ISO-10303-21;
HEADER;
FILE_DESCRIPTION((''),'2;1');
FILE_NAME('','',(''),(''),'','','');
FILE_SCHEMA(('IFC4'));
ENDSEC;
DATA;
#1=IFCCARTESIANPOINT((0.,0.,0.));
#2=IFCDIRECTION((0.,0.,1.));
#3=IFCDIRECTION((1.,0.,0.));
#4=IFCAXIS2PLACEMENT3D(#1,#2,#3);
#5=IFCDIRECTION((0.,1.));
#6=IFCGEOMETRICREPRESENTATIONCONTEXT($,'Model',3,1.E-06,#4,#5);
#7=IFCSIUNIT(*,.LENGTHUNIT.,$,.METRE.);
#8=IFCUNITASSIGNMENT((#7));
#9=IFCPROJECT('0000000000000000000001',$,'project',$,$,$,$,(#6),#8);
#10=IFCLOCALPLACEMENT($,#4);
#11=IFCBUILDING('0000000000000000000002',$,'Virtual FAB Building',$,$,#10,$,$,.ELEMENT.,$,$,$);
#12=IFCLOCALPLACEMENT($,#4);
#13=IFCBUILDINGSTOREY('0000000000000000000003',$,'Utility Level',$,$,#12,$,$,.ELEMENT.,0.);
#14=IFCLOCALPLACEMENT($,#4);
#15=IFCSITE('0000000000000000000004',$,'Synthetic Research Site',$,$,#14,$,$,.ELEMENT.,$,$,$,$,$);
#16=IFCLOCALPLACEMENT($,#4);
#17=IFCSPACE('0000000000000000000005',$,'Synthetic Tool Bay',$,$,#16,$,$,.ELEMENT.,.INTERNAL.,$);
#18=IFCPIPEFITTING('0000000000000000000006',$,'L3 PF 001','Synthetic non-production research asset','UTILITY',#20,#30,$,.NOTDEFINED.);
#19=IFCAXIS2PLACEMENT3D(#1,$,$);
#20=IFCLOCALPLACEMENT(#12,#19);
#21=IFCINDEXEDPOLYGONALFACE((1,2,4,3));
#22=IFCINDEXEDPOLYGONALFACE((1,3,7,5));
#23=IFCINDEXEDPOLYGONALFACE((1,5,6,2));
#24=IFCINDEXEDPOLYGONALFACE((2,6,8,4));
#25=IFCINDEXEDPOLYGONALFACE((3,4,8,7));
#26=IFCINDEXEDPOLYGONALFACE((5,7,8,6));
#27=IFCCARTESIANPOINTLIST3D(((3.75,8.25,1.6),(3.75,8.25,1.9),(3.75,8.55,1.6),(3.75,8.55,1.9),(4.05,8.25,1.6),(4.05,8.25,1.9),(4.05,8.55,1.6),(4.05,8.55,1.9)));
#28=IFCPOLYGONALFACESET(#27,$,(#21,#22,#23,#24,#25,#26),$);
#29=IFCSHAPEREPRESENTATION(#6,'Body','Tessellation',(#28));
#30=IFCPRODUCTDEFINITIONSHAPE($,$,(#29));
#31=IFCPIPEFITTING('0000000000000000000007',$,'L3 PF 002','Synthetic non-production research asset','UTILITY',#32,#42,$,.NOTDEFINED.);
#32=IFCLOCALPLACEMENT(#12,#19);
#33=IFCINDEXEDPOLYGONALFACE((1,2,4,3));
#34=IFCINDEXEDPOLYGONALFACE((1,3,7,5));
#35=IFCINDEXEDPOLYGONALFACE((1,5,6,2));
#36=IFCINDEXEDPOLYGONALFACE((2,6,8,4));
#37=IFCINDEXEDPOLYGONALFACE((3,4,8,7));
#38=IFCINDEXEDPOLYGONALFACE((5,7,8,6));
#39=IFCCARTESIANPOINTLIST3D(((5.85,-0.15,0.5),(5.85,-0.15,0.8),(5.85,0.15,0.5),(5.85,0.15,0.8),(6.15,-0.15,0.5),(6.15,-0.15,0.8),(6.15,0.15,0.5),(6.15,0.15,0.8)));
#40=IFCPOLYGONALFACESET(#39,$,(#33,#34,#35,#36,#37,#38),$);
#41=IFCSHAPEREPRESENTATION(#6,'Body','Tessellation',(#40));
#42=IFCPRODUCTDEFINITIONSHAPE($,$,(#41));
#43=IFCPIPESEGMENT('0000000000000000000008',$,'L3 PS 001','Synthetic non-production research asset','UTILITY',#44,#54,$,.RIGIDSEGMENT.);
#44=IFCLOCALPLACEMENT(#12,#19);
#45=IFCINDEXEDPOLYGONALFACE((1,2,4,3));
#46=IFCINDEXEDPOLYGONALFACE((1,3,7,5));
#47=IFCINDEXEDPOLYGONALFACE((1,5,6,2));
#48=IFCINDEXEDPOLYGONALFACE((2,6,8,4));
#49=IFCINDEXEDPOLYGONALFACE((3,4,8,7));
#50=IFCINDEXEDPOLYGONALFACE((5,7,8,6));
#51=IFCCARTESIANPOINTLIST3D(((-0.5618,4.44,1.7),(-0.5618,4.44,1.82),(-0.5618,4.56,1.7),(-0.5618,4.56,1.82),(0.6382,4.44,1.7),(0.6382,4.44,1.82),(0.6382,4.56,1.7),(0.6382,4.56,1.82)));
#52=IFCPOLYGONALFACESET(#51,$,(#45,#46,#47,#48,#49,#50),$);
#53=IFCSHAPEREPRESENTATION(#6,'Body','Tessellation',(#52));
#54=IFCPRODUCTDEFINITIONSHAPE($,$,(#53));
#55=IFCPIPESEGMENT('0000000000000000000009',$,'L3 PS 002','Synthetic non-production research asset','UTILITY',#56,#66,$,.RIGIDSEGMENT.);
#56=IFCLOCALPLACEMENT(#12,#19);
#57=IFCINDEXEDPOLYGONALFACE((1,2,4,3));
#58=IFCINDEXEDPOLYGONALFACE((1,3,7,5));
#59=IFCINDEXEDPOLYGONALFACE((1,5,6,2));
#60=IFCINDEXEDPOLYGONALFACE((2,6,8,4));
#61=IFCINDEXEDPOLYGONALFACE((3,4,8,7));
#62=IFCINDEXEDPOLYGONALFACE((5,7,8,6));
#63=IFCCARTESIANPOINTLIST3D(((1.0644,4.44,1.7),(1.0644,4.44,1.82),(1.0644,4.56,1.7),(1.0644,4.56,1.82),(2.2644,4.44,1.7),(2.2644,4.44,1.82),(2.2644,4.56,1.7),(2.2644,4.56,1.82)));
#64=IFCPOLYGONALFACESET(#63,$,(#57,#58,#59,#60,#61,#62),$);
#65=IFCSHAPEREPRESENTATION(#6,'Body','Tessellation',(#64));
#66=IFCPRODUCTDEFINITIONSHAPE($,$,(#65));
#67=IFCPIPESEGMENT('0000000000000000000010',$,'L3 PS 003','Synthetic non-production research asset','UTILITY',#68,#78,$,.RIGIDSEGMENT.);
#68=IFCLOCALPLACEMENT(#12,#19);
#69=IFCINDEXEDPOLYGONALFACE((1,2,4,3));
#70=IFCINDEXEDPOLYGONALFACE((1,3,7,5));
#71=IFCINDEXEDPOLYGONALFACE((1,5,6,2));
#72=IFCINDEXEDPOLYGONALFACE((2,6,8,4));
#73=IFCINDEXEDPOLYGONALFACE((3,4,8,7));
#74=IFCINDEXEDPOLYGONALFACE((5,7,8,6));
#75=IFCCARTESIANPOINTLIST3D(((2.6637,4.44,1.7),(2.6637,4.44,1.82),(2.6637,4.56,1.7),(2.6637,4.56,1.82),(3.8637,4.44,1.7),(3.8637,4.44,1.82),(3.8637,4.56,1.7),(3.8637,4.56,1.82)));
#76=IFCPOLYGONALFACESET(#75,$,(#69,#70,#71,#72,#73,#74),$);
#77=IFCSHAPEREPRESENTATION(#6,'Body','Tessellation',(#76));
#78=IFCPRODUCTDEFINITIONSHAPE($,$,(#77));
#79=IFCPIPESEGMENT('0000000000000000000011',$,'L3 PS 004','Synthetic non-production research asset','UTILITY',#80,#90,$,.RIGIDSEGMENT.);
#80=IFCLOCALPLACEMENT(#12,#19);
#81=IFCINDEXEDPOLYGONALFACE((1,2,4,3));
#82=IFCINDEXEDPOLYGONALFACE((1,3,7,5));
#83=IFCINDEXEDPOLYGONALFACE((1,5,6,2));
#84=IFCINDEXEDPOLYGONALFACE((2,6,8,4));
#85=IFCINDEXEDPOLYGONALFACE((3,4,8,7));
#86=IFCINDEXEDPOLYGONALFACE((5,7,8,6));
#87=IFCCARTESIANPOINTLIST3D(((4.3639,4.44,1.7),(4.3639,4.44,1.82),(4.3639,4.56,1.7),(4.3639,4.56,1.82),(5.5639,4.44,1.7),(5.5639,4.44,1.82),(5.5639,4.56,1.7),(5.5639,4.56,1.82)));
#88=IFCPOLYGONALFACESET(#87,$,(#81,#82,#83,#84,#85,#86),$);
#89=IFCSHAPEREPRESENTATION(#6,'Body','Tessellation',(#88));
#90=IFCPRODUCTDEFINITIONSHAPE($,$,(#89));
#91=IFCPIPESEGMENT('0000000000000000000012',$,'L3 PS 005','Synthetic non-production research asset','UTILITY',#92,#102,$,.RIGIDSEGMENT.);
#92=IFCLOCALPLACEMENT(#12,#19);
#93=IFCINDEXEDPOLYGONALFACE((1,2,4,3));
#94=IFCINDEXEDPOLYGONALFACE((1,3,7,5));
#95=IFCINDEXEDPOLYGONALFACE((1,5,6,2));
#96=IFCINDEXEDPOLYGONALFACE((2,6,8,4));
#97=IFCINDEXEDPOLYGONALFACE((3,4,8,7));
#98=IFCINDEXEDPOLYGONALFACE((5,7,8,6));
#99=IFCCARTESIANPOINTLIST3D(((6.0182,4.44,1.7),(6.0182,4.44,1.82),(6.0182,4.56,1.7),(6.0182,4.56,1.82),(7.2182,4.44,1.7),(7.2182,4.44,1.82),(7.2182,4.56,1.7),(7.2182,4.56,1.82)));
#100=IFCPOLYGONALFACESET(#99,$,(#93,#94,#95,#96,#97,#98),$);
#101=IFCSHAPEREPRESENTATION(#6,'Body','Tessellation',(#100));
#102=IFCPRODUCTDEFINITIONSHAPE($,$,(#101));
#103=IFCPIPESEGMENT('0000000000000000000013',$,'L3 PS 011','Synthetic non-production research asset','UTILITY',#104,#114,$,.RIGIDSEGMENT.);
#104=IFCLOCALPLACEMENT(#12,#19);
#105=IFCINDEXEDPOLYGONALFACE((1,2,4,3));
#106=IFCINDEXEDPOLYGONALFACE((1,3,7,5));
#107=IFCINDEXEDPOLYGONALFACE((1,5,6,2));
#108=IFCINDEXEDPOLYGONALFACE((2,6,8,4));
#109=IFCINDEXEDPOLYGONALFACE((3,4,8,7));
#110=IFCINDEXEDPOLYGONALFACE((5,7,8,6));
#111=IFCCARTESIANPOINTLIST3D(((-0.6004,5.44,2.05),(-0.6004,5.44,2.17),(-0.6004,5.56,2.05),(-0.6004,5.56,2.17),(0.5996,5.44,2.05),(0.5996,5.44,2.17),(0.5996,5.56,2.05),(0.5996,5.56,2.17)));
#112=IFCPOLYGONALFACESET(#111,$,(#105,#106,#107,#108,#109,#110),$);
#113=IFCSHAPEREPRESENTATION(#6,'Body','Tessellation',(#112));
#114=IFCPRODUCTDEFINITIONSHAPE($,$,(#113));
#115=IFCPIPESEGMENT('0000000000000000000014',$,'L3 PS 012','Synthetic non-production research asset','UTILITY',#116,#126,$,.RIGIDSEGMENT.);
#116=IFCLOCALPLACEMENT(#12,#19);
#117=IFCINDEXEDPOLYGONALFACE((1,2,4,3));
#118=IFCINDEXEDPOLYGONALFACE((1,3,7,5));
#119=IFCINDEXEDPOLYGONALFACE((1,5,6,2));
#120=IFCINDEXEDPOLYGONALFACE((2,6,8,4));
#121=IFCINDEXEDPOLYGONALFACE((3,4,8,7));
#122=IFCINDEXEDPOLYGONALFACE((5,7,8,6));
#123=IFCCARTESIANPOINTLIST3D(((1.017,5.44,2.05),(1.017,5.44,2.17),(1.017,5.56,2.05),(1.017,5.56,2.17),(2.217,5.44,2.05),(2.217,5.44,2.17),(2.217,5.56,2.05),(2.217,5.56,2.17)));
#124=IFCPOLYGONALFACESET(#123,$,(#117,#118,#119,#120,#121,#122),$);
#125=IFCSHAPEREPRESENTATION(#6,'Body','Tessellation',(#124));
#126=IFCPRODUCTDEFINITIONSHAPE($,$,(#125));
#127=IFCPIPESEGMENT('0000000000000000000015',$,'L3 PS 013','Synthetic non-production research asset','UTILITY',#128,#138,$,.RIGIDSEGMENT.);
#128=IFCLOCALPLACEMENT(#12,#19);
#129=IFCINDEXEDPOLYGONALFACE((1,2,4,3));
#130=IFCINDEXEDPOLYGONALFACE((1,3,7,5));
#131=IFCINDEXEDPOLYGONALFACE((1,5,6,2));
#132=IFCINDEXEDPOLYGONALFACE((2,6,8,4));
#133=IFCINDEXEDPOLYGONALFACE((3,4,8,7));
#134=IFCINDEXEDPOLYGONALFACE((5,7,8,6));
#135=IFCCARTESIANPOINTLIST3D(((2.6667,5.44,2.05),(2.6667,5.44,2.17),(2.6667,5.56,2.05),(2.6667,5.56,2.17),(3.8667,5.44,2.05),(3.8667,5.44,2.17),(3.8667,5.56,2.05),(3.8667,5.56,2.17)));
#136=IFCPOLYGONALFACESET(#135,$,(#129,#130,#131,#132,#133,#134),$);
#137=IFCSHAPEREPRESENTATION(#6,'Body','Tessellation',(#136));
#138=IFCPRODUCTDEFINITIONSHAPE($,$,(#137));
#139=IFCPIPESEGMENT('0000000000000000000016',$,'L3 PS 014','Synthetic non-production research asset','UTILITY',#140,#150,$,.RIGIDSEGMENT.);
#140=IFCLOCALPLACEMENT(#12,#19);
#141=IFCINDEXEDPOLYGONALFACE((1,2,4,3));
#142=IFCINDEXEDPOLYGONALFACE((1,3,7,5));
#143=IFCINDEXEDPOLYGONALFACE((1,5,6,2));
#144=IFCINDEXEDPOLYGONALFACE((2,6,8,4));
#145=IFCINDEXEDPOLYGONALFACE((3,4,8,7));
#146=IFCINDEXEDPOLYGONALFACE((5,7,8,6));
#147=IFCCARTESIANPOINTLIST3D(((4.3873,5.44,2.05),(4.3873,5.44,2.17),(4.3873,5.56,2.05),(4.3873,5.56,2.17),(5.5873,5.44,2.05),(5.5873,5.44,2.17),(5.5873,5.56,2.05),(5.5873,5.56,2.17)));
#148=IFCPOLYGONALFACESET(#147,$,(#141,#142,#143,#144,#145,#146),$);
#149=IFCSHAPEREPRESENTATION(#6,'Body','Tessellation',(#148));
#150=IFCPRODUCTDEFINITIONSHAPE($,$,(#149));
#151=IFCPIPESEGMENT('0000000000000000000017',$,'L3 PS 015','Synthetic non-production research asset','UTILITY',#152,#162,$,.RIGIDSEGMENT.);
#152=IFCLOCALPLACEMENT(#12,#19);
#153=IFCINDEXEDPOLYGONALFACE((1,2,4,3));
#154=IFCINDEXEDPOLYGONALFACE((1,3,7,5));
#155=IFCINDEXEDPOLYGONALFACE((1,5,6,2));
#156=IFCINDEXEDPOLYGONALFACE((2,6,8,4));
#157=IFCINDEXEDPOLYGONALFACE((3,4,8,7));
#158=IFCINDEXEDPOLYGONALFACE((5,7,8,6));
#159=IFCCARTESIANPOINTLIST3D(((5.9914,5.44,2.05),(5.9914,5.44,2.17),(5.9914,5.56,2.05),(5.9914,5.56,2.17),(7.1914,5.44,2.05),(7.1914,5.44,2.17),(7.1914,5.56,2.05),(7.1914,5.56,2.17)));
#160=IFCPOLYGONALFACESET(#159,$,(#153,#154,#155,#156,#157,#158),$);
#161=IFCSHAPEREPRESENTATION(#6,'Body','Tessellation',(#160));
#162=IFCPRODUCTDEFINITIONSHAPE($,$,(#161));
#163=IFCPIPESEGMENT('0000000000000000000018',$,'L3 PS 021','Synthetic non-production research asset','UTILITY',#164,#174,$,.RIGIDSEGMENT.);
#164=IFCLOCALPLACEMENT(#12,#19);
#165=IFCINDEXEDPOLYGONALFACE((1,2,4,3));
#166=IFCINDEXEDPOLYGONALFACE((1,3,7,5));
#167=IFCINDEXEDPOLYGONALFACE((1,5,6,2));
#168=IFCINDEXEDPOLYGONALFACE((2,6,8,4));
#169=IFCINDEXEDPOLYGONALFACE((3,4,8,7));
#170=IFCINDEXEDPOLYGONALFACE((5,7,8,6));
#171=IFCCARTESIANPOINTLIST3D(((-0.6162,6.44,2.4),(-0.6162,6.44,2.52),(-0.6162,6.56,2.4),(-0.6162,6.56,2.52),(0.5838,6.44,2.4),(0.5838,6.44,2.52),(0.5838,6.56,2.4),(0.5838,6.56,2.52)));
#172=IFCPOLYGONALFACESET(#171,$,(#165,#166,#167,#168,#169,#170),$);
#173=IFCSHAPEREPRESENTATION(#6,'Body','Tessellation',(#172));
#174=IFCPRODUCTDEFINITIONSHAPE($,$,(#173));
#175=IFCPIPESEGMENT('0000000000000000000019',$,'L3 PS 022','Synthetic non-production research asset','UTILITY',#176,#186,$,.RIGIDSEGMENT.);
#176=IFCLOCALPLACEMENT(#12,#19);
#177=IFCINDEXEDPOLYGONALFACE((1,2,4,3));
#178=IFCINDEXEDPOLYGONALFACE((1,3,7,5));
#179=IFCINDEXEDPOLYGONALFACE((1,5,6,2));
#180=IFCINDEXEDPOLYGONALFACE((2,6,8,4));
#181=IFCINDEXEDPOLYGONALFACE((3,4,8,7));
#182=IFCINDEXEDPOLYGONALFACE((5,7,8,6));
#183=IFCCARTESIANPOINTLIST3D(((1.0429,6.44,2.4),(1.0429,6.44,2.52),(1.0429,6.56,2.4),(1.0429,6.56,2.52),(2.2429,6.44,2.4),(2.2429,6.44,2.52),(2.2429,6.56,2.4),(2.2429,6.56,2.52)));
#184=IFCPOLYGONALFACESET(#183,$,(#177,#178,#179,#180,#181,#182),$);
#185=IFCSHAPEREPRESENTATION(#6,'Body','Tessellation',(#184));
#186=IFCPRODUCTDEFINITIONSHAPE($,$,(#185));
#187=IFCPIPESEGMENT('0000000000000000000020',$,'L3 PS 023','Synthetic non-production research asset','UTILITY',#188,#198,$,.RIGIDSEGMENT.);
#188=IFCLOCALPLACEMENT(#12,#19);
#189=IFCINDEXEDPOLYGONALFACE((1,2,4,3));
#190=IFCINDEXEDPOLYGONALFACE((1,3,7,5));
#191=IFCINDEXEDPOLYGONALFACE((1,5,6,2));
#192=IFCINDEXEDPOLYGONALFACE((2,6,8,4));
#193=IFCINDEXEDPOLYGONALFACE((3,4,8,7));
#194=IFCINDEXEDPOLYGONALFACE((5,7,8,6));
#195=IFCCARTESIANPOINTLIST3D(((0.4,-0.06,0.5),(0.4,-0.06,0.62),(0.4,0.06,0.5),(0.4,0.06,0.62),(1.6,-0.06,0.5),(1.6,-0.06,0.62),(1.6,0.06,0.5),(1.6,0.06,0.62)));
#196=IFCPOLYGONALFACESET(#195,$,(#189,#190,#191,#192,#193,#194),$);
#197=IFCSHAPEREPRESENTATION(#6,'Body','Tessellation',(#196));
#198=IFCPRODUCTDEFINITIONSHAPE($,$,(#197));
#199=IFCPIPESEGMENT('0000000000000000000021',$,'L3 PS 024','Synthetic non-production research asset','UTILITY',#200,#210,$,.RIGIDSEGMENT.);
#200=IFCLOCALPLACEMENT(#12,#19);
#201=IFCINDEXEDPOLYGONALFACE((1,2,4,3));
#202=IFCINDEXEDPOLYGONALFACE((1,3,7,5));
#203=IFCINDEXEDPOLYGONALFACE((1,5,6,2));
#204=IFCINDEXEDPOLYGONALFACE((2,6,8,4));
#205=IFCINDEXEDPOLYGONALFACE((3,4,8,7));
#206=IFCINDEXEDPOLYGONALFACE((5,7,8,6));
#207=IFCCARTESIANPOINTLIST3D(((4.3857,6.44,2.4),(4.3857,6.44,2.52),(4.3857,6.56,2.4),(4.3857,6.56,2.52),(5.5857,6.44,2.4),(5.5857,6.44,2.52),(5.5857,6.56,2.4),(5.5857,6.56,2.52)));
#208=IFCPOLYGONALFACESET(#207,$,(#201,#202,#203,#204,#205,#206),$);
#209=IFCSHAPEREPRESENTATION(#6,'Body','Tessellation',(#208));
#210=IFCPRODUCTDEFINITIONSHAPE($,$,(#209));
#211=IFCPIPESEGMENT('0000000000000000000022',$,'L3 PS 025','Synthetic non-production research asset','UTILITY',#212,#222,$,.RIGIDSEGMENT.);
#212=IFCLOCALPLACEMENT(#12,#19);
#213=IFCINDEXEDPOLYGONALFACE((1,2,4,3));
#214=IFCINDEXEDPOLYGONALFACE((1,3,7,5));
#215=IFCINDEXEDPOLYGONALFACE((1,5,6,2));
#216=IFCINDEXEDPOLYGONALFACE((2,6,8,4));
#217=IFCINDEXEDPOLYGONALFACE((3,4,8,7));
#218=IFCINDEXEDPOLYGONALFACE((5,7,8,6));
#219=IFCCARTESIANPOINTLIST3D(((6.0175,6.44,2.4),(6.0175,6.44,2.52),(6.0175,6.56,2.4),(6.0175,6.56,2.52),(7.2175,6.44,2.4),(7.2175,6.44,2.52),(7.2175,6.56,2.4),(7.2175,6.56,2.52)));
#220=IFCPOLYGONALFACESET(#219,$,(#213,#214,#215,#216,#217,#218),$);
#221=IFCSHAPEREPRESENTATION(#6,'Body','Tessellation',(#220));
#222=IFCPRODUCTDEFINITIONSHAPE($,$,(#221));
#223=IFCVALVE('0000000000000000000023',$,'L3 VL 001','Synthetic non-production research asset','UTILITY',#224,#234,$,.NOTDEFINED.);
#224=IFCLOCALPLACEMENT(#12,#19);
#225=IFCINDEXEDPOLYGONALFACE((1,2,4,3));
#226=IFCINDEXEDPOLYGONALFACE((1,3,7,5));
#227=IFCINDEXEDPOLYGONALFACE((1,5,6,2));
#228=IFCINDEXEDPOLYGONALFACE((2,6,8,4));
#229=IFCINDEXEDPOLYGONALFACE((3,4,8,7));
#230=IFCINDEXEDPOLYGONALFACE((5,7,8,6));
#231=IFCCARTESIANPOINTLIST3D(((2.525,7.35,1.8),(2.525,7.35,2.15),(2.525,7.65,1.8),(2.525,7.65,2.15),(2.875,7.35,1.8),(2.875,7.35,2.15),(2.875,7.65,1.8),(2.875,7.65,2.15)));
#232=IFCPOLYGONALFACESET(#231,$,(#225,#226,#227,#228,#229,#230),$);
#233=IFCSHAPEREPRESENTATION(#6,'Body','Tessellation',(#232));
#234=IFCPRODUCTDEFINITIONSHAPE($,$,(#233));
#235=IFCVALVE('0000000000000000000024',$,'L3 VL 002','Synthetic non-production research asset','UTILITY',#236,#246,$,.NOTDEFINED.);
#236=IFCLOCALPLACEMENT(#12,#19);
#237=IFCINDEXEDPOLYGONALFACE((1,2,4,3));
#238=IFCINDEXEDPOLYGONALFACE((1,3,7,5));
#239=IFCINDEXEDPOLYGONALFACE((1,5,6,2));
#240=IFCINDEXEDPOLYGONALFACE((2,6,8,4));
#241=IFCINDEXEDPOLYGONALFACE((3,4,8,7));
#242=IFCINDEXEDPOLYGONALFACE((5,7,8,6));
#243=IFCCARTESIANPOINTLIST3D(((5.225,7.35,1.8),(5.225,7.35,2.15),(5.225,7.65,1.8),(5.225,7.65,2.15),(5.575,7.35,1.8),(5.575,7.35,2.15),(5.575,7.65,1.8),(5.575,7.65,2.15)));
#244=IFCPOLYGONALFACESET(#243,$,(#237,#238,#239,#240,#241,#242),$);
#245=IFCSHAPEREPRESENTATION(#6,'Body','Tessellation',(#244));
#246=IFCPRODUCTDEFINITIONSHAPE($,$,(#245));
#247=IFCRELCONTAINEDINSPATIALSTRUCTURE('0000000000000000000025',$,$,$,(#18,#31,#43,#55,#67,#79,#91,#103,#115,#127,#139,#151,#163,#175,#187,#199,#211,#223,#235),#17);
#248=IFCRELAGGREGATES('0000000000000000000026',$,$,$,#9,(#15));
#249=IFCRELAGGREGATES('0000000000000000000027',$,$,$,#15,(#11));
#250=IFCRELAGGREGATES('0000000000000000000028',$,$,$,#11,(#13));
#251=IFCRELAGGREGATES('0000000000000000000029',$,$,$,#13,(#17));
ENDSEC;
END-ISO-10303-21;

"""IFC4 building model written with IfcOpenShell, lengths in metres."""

from ifc_helpers import new_model, si_unit, direction, frame, origin_with_axes, origin_2d_with_axis, place, context, project, spatial, rectangle, extrude, element, save


model = new_model("IFC4")

# Units and contexts
model_context = context("Model", 3, precision=1e-06, world=origin_with_axes(), true_north=direction((0.0, 1.0)))
ifc_project = project(units=[si_unit("LENGTHUNIT", "METRE")], contexts=[model_context])

# Site, building, storey, space
site_placement = place(None, origin_with_axes())
site = spatial("IfcSite", under=ifc_project, at=site_placement, Name="Synthetic Research Site", CompositionType="ELEMENT")
building_placement = place(None, origin_with_axes())
building = spatial("IfcBuilding", under=site, at=building_placement, Name="Virtual FAB Building", CompositionType="ELEMENT")
storey_placement = place(None, origin_with_axes())
storey = spatial("IfcBuildingStorey", under=building, at=storey_placement, Name="Utility Level", CompositionType="ELEMENT", Elevation=0.0)
space_placement = place(None, origin_with_axes())
space = spatial("IfcSpace", under=storey, at=space_placement, Name="Synthetic Tool Bay", CompositionType="ELEMENT", PredefinedType="INTERNAL")

# Pipe fittings
for number, where, z_axis, x_axis, name in (
    (1, (3.9, 8.4, 1.6), (0.0, 0.0, 1.0), (1.0, 0.0, 0.0), "L3 PF 001"),
    (2, (6.0, 0.0, 0.5), (0.0, 0.0, 1.0), (1.0, 0.0, 0.0), "L3 PF 002"),
):
    element("IfcPipeFitting", number, at=place(None, frame(where, z_axis=z_axis, x_axis=x_axis)), inside=space, Name=name, Description="Synthetic non-production research asset", ObjectType="UTILITY", PredefinedType="NOTDEFINED", context=model_context, shape_type="SweptSolid", body=[
        extrude(rectangle(XDim=0.3, YDim=0.3, at=origin_2d_with_axis()), origin_with_axes(), (0.0, 0.0, 1.0), 0.3),
    ])

# Pipe segments
for number, where, z_axis, x_axis, name in (
    (3, (0.0382, 4.5, 1.7), (0.0, 0.0, 1.0), (1.0, 0.0, 0.0), "L3 PS 001"),
    (4, (1.6644, 4.5, 1.7), (0.0, 0.0, 1.0), (1.0, 0.0, 0.0), "L3 PS 002"),
    (5, (3.2637, 4.5, 1.7), (0.0, 0.0, 1.0), (1.0, 0.0, 0.0), "L3 PS 003"),
    (6, (4.9639, 4.5, 1.7), (0.0, 0.0, 1.0), (1.0, 0.0, 0.0), "L3 PS 004"),
    (7, (6.6182, 4.5, 1.7), (0.0, 0.0, 1.0), (1.0, 0.0, 0.0), "L3 PS 005"),
    (8, (-0.0004, 5.5, 2.05), (0.0, 0.0, 1.0), (1.0, 0.0, 0.0), "L3 PS 011"),
    (9, (1.617, 5.5, 2.05), (0.0, 0.0, 1.0), (1.0, 0.0, 0.0), "L3 PS 012"),
    (10, (3.2667, 5.5, 2.05), (0.0, 0.0, 1.0), (1.0, 0.0, 0.0), "L3 PS 013"),
    (11, (4.9873, 5.5, 2.05), (0.0, 0.0, 1.0), (1.0, 0.0, 0.0), "L3 PS 014"),
    (12, (6.5914, 5.5, 2.05), (0.0, 0.0, 1.0), (1.0, 0.0, 0.0), "L3 PS 015"),
    (13, (-0.0162, 6.5, 2.4), (0.0, 0.0, 1.0), (1.0, 0.0, 0.0), "L3 PS 021"),
    (14, (1.6429, 6.5, 2.4), (0.0, 0.0, 1.0), (1.0, 0.0, 0.0), "L3 PS 022"),
    (15, (1.0, 0.0, 0.5), (0.0, 0.0, 1.0), (1.0, 0.0, 0.0), "L3 PS 023"),
    (16, (4.9857, 6.5, 2.4), (0.0, 0.0, 1.0), (1.0, 0.0, 0.0), "L3 PS 024"),
    (17, (6.6175, 6.5, 2.4), (0.0, 0.0, 1.0), (1.0, 0.0, 0.0), "L3 PS 025"),
):
    element("IfcPipeSegment", number, at=place(None, frame(where, z_axis=z_axis, x_axis=x_axis)), inside=space, Name=name, Description="Synthetic non-production research asset", ObjectType="UTILITY", PredefinedType="RIGIDSEGMENT", context=model_context, shape_type="SweptSolid", body=[
        extrude(rectangle(XDim=1.2, YDim=0.12, at=origin_2d_with_axis()), origin_with_axes(), (0.0, 0.0, 1.0), 0.12),
    ])

# Valves
for number, where, z_axis, x_axis, name in (
    (18, (2.7, 7.5, 1.8), (0.0, 0.0, 1.0), (1.0, 0.0, 0.0), "L3 VL 001"),
    (19, (5.4, 7.5, 1.8), (0.0, 0.0, 1.0), (1.0, 0.0, 0.0), "L3 VL 002"),
):
    element("IfcValve", number, at=place(None, frame(where, z_axis=z_axis, x_axis=x_axis)), inside=space, Name=name, Description="Synthetic non-production research asset", ObjectType="UTILITY", PredefinedType="NOTDEFINED", context=model_context, shape_type="SweptSolid", body=[
        extrude(rectangle(XDim=0.35, YDim=0.3, at=origin_2d_with_axis()), origin_with_axes(), (0.0, 0.0, 1.0), 0.35),
    ])

save(model, "model.ifc")
